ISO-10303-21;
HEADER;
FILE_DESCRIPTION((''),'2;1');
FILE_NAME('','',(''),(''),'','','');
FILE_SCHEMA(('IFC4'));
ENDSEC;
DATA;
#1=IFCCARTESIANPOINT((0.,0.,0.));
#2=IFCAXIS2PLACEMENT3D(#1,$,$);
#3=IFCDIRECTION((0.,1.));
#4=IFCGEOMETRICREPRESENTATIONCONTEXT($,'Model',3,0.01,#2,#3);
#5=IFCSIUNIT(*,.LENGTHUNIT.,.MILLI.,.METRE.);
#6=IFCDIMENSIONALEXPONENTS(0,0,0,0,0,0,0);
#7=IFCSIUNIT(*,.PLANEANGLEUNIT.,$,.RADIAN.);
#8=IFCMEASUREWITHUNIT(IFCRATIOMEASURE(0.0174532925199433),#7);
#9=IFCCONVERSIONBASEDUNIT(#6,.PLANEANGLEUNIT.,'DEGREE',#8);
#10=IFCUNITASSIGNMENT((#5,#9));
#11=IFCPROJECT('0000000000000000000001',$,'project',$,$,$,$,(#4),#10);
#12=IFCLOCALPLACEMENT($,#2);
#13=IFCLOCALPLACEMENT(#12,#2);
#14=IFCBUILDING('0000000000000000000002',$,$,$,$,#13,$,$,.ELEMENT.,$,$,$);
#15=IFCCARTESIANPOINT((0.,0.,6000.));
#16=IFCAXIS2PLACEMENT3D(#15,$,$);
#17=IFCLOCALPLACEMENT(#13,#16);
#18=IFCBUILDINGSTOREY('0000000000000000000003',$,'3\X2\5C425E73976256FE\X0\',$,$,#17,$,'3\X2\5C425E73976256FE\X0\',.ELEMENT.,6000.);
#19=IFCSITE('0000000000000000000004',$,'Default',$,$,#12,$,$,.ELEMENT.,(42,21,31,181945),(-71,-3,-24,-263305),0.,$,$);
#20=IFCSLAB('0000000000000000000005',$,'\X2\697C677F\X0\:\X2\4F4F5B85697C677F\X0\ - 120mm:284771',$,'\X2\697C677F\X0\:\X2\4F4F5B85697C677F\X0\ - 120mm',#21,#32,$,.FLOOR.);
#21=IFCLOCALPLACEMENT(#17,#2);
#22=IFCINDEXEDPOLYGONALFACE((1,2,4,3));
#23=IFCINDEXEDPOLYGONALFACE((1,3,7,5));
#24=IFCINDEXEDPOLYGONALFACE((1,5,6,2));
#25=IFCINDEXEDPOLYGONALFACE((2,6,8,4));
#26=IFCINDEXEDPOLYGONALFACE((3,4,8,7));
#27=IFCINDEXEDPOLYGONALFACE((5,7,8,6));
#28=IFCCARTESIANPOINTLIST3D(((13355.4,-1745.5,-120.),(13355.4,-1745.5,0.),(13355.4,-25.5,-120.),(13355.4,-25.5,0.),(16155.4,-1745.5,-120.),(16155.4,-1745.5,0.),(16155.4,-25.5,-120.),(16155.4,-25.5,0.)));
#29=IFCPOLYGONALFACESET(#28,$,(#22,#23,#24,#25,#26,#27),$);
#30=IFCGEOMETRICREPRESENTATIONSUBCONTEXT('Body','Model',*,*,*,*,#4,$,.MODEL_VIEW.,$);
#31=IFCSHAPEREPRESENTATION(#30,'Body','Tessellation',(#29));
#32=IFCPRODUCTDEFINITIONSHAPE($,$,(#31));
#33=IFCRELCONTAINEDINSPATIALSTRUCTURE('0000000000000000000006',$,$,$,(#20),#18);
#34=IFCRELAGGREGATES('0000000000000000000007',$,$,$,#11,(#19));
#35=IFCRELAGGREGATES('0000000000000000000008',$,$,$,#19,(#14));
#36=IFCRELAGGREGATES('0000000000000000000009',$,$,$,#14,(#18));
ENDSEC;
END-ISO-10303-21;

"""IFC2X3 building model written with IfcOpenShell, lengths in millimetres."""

from ifc_helpers import new_model, entity, si_unit, converted_unit, direction, frame, origin, origin_2d_with_axis, place, context, subcontext, project, spatial, rectangle, extrude, element, save


model = new_model("IFC2X3")

# Units and contexts
model_context = context("Model", 3, precision=0.01, world=origin(), true_north=direction((0.0, 1.0)))
body_context = subcontext(model_context, "Body", "Model", "MODEL_VIEW")
ifc_project = project(units=[si_unit("LENGTHUNIT", "METRE", prefix="MILLI"), converted_unit("PLANEANGLEUNIT", "DEGREE", entity("IfcRatioMeasure", 0.0174532925199433), si_unit("PLANEANGLEUNIT", "RADIAN"), dimensions=[0, 0, 0, 0, 0, 0, 0])], contexts=[model_context])

# Site, building, storey
site_placement = place(None, origin())
site = spatial("IfcSite", under=ifc_project, at=site_placement, Name="Default", CompositionType="ELEMENT", RefLatitude=(42, 21, 31, 181945), RefLongitude=(-71, -3, -24, -263305), RefElevation=0.0)
building_placement = place(site_placement, origin())
building = spatial("IfcBuilding", under=site, at=building_placement, CompositionType="ELEMENT")
storey_placement = place(building_placement, frame((0.0, 0.0, 6000.0)))
storey = spatial("IfcBuildingStorey", under=building, at=storey_placement, Name="3层平面图", LongName="3层平面图", CompositionType="ELEMENT", Elevation=6000.0)

# Slab
slab_placement = place(storey_placement, origin())
element("IfcSlab", 1, at=slab_placement, inside=storey, Name="楼板:住宅楼板 - 120mm:284771", ObjectType="楼板:住宅楼板 - 120mm", PredefinedType="FLOOR", context=body_context, shape_type="SweptSolid", body=[
    extrude(rectangle(XDim=1720.0, YDim=2800.0, at=origin_2d_with_axis()), frame((14755.4, -885.5, 0.0), z_axis=(0.0, 0.0, -1.0), x_axis=(0.0, 1.0, 0.0)), (0.0, 0.0, 1.0), 120.0),
])

save(model, "model.ifc")
